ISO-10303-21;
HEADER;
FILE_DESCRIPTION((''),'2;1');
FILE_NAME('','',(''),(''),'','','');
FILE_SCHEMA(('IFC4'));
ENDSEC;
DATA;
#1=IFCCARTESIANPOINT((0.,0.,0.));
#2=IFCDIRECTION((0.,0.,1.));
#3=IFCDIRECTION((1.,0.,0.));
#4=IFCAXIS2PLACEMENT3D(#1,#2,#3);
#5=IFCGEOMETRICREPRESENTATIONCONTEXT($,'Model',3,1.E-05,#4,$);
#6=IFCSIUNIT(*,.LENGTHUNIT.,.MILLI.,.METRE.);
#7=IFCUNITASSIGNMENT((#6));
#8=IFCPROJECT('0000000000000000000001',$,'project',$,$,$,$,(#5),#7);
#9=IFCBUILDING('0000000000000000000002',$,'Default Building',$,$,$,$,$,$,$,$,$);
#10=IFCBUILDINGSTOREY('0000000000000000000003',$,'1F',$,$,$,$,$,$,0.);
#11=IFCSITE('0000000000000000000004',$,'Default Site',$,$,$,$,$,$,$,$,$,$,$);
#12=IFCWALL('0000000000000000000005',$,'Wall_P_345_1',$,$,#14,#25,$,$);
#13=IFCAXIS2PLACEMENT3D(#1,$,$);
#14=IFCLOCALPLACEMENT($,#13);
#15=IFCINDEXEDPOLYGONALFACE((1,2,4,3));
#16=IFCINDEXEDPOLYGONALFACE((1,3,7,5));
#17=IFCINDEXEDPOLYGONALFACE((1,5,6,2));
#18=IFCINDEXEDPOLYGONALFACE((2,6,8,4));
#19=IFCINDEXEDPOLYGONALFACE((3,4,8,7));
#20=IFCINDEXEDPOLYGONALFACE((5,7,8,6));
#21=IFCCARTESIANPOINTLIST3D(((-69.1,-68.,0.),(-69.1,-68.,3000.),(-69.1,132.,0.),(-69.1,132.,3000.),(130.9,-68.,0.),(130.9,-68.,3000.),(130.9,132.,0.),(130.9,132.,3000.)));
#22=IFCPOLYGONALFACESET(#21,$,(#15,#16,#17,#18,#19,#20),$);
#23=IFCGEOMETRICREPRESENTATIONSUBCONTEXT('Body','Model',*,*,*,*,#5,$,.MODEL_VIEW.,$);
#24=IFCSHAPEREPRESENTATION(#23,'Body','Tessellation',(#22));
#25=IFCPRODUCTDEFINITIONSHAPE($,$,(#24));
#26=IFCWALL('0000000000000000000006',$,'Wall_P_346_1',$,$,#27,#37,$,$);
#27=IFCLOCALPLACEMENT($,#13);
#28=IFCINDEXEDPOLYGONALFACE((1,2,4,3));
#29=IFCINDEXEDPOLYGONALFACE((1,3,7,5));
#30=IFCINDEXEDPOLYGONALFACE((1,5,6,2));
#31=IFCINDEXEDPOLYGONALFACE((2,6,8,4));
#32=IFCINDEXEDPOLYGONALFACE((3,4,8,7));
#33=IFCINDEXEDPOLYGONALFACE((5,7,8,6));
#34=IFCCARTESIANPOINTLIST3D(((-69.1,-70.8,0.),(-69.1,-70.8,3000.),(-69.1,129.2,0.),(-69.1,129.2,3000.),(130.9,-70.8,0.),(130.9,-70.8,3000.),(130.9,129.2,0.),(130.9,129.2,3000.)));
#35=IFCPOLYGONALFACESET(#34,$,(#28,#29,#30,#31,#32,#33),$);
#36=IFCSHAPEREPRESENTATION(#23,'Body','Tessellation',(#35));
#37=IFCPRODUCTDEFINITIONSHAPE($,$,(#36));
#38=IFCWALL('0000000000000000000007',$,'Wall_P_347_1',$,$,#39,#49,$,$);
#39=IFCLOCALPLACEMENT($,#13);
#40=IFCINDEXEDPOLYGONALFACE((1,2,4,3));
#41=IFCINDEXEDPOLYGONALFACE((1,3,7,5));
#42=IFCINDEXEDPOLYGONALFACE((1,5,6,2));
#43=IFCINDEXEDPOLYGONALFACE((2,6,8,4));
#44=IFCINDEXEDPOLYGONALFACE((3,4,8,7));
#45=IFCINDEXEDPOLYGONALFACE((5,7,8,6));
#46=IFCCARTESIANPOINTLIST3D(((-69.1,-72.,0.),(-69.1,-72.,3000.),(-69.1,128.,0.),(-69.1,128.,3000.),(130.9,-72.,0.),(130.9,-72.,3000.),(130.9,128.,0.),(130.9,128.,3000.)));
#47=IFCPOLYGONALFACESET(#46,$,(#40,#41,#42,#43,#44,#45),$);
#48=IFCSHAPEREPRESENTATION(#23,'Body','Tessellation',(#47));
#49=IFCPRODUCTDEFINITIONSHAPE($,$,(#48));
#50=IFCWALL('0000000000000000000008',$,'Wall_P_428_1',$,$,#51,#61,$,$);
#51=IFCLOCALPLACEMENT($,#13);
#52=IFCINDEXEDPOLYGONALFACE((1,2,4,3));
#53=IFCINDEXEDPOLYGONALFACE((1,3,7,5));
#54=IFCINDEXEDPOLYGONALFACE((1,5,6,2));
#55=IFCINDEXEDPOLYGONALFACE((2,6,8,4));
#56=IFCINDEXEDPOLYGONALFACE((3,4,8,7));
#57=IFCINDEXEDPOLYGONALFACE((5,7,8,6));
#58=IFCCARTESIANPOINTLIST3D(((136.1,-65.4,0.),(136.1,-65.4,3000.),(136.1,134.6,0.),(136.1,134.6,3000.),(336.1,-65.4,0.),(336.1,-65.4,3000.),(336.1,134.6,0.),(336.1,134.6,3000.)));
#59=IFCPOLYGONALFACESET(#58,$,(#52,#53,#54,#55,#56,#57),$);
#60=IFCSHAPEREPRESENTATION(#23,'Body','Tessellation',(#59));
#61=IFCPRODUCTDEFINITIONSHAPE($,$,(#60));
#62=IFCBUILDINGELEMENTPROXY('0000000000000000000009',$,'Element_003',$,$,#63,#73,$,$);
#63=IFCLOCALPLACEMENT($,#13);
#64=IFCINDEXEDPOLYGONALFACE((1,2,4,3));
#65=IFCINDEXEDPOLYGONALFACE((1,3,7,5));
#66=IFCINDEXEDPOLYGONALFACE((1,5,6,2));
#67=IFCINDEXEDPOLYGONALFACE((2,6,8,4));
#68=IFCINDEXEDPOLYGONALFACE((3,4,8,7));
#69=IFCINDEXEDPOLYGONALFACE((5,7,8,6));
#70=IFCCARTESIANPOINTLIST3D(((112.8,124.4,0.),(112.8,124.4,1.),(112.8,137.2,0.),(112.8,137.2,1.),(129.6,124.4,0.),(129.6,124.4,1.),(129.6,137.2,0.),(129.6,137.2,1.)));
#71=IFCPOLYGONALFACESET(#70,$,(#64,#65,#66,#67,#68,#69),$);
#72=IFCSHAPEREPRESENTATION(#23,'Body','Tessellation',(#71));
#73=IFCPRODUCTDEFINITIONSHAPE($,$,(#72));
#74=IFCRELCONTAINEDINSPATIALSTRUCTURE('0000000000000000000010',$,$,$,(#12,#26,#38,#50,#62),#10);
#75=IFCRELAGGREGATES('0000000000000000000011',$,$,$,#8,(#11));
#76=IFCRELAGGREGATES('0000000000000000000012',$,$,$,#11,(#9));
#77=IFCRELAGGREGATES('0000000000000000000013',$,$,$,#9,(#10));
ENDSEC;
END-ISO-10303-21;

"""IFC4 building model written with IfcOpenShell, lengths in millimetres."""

from ifc_helpers import new_model, si_unit, frame, origin, origin_with_axes, place, context, subcontext, project, spatial, indexed_curve, rectangle, outline, extrude, element, save


model = new_model("IFC4")

# Units and contexts
model_context = context("Model", 3, precision=1e-05, world=origin_with_axes())
body_context = subcontext(model_context, "Body", "Model", "MODEL_VIEW")
ifc_project = project(units=[si_unit("LENGTHUNIT", "METRE", prefix="MILLI")], contexts=[model_context])

# Site, building, storey
site = spatial("IfcSite", under=ifc_project, Name="Default Site")
building = spatial("IfcBuilding", under=site, Name="Default Building")
storey = spatial("IfcBuildingStorey", under=building, Name="1F", Elevation=0.0)

# Walls
for number, where, z_axis, x_axis, name in (
    (1, (130.9, 132.0, 0.0), (0.0, 0.0, 1.0), (-1.0, 0.0, 0.0), "Wall_P_345_1"),
    (2, (130.9, 129.2, 0.0), (0.0, 0.0, 1.0), (-1.0, 0.0, 0.0), "Wall_P_346_1"),
    (3, (130.9, 128.0, 0.0), (0.0, 0.0, 1.0), (-1.0, 0.0, 0.0), "Wall_P_347_1"),
    (4, (136.1, 134.6, 0.0), (0.0, 0.0, 1.0), (0.0, -1.0, 0.0), "Wall_P_428_1"),
):
    element("IfcWall", number, at=place(None, frame(where, z_axis=z_axis, x_axis=x_axis)), inside=storey, Name=name, context=body_context, shape_type="SweptSolid", body=[
        extrude(outline(indexed_curve([(0.0, 0.0), (0.0, 200.0), (200.0, 200.0), (200.0, 0.0), (0.0, 0.0)], self_intersect=False)), origin_with_axes(), (0.0, 0.0, 1.0), 3000.0),
    ])

# Building element proxy
proxy_1_placement = place(None, frame((121.2, 130.8, 0.0), z_axis=(0.0, 0.0, 1.0), x_axis=(1.0, 0.0, 0.0)))
element("IfcBuildingElementProxy", 5, at=proxy_1_placement, inside=storey, Name="Element_003", context=body_context, shape_type="SweptSolid", body=[
    extrude(rectangle(XDim=16.8, YDim=12.8), origin(), (0.0, 0.0, 1.0), 1.0),
])

save(model, "model.ifc")
